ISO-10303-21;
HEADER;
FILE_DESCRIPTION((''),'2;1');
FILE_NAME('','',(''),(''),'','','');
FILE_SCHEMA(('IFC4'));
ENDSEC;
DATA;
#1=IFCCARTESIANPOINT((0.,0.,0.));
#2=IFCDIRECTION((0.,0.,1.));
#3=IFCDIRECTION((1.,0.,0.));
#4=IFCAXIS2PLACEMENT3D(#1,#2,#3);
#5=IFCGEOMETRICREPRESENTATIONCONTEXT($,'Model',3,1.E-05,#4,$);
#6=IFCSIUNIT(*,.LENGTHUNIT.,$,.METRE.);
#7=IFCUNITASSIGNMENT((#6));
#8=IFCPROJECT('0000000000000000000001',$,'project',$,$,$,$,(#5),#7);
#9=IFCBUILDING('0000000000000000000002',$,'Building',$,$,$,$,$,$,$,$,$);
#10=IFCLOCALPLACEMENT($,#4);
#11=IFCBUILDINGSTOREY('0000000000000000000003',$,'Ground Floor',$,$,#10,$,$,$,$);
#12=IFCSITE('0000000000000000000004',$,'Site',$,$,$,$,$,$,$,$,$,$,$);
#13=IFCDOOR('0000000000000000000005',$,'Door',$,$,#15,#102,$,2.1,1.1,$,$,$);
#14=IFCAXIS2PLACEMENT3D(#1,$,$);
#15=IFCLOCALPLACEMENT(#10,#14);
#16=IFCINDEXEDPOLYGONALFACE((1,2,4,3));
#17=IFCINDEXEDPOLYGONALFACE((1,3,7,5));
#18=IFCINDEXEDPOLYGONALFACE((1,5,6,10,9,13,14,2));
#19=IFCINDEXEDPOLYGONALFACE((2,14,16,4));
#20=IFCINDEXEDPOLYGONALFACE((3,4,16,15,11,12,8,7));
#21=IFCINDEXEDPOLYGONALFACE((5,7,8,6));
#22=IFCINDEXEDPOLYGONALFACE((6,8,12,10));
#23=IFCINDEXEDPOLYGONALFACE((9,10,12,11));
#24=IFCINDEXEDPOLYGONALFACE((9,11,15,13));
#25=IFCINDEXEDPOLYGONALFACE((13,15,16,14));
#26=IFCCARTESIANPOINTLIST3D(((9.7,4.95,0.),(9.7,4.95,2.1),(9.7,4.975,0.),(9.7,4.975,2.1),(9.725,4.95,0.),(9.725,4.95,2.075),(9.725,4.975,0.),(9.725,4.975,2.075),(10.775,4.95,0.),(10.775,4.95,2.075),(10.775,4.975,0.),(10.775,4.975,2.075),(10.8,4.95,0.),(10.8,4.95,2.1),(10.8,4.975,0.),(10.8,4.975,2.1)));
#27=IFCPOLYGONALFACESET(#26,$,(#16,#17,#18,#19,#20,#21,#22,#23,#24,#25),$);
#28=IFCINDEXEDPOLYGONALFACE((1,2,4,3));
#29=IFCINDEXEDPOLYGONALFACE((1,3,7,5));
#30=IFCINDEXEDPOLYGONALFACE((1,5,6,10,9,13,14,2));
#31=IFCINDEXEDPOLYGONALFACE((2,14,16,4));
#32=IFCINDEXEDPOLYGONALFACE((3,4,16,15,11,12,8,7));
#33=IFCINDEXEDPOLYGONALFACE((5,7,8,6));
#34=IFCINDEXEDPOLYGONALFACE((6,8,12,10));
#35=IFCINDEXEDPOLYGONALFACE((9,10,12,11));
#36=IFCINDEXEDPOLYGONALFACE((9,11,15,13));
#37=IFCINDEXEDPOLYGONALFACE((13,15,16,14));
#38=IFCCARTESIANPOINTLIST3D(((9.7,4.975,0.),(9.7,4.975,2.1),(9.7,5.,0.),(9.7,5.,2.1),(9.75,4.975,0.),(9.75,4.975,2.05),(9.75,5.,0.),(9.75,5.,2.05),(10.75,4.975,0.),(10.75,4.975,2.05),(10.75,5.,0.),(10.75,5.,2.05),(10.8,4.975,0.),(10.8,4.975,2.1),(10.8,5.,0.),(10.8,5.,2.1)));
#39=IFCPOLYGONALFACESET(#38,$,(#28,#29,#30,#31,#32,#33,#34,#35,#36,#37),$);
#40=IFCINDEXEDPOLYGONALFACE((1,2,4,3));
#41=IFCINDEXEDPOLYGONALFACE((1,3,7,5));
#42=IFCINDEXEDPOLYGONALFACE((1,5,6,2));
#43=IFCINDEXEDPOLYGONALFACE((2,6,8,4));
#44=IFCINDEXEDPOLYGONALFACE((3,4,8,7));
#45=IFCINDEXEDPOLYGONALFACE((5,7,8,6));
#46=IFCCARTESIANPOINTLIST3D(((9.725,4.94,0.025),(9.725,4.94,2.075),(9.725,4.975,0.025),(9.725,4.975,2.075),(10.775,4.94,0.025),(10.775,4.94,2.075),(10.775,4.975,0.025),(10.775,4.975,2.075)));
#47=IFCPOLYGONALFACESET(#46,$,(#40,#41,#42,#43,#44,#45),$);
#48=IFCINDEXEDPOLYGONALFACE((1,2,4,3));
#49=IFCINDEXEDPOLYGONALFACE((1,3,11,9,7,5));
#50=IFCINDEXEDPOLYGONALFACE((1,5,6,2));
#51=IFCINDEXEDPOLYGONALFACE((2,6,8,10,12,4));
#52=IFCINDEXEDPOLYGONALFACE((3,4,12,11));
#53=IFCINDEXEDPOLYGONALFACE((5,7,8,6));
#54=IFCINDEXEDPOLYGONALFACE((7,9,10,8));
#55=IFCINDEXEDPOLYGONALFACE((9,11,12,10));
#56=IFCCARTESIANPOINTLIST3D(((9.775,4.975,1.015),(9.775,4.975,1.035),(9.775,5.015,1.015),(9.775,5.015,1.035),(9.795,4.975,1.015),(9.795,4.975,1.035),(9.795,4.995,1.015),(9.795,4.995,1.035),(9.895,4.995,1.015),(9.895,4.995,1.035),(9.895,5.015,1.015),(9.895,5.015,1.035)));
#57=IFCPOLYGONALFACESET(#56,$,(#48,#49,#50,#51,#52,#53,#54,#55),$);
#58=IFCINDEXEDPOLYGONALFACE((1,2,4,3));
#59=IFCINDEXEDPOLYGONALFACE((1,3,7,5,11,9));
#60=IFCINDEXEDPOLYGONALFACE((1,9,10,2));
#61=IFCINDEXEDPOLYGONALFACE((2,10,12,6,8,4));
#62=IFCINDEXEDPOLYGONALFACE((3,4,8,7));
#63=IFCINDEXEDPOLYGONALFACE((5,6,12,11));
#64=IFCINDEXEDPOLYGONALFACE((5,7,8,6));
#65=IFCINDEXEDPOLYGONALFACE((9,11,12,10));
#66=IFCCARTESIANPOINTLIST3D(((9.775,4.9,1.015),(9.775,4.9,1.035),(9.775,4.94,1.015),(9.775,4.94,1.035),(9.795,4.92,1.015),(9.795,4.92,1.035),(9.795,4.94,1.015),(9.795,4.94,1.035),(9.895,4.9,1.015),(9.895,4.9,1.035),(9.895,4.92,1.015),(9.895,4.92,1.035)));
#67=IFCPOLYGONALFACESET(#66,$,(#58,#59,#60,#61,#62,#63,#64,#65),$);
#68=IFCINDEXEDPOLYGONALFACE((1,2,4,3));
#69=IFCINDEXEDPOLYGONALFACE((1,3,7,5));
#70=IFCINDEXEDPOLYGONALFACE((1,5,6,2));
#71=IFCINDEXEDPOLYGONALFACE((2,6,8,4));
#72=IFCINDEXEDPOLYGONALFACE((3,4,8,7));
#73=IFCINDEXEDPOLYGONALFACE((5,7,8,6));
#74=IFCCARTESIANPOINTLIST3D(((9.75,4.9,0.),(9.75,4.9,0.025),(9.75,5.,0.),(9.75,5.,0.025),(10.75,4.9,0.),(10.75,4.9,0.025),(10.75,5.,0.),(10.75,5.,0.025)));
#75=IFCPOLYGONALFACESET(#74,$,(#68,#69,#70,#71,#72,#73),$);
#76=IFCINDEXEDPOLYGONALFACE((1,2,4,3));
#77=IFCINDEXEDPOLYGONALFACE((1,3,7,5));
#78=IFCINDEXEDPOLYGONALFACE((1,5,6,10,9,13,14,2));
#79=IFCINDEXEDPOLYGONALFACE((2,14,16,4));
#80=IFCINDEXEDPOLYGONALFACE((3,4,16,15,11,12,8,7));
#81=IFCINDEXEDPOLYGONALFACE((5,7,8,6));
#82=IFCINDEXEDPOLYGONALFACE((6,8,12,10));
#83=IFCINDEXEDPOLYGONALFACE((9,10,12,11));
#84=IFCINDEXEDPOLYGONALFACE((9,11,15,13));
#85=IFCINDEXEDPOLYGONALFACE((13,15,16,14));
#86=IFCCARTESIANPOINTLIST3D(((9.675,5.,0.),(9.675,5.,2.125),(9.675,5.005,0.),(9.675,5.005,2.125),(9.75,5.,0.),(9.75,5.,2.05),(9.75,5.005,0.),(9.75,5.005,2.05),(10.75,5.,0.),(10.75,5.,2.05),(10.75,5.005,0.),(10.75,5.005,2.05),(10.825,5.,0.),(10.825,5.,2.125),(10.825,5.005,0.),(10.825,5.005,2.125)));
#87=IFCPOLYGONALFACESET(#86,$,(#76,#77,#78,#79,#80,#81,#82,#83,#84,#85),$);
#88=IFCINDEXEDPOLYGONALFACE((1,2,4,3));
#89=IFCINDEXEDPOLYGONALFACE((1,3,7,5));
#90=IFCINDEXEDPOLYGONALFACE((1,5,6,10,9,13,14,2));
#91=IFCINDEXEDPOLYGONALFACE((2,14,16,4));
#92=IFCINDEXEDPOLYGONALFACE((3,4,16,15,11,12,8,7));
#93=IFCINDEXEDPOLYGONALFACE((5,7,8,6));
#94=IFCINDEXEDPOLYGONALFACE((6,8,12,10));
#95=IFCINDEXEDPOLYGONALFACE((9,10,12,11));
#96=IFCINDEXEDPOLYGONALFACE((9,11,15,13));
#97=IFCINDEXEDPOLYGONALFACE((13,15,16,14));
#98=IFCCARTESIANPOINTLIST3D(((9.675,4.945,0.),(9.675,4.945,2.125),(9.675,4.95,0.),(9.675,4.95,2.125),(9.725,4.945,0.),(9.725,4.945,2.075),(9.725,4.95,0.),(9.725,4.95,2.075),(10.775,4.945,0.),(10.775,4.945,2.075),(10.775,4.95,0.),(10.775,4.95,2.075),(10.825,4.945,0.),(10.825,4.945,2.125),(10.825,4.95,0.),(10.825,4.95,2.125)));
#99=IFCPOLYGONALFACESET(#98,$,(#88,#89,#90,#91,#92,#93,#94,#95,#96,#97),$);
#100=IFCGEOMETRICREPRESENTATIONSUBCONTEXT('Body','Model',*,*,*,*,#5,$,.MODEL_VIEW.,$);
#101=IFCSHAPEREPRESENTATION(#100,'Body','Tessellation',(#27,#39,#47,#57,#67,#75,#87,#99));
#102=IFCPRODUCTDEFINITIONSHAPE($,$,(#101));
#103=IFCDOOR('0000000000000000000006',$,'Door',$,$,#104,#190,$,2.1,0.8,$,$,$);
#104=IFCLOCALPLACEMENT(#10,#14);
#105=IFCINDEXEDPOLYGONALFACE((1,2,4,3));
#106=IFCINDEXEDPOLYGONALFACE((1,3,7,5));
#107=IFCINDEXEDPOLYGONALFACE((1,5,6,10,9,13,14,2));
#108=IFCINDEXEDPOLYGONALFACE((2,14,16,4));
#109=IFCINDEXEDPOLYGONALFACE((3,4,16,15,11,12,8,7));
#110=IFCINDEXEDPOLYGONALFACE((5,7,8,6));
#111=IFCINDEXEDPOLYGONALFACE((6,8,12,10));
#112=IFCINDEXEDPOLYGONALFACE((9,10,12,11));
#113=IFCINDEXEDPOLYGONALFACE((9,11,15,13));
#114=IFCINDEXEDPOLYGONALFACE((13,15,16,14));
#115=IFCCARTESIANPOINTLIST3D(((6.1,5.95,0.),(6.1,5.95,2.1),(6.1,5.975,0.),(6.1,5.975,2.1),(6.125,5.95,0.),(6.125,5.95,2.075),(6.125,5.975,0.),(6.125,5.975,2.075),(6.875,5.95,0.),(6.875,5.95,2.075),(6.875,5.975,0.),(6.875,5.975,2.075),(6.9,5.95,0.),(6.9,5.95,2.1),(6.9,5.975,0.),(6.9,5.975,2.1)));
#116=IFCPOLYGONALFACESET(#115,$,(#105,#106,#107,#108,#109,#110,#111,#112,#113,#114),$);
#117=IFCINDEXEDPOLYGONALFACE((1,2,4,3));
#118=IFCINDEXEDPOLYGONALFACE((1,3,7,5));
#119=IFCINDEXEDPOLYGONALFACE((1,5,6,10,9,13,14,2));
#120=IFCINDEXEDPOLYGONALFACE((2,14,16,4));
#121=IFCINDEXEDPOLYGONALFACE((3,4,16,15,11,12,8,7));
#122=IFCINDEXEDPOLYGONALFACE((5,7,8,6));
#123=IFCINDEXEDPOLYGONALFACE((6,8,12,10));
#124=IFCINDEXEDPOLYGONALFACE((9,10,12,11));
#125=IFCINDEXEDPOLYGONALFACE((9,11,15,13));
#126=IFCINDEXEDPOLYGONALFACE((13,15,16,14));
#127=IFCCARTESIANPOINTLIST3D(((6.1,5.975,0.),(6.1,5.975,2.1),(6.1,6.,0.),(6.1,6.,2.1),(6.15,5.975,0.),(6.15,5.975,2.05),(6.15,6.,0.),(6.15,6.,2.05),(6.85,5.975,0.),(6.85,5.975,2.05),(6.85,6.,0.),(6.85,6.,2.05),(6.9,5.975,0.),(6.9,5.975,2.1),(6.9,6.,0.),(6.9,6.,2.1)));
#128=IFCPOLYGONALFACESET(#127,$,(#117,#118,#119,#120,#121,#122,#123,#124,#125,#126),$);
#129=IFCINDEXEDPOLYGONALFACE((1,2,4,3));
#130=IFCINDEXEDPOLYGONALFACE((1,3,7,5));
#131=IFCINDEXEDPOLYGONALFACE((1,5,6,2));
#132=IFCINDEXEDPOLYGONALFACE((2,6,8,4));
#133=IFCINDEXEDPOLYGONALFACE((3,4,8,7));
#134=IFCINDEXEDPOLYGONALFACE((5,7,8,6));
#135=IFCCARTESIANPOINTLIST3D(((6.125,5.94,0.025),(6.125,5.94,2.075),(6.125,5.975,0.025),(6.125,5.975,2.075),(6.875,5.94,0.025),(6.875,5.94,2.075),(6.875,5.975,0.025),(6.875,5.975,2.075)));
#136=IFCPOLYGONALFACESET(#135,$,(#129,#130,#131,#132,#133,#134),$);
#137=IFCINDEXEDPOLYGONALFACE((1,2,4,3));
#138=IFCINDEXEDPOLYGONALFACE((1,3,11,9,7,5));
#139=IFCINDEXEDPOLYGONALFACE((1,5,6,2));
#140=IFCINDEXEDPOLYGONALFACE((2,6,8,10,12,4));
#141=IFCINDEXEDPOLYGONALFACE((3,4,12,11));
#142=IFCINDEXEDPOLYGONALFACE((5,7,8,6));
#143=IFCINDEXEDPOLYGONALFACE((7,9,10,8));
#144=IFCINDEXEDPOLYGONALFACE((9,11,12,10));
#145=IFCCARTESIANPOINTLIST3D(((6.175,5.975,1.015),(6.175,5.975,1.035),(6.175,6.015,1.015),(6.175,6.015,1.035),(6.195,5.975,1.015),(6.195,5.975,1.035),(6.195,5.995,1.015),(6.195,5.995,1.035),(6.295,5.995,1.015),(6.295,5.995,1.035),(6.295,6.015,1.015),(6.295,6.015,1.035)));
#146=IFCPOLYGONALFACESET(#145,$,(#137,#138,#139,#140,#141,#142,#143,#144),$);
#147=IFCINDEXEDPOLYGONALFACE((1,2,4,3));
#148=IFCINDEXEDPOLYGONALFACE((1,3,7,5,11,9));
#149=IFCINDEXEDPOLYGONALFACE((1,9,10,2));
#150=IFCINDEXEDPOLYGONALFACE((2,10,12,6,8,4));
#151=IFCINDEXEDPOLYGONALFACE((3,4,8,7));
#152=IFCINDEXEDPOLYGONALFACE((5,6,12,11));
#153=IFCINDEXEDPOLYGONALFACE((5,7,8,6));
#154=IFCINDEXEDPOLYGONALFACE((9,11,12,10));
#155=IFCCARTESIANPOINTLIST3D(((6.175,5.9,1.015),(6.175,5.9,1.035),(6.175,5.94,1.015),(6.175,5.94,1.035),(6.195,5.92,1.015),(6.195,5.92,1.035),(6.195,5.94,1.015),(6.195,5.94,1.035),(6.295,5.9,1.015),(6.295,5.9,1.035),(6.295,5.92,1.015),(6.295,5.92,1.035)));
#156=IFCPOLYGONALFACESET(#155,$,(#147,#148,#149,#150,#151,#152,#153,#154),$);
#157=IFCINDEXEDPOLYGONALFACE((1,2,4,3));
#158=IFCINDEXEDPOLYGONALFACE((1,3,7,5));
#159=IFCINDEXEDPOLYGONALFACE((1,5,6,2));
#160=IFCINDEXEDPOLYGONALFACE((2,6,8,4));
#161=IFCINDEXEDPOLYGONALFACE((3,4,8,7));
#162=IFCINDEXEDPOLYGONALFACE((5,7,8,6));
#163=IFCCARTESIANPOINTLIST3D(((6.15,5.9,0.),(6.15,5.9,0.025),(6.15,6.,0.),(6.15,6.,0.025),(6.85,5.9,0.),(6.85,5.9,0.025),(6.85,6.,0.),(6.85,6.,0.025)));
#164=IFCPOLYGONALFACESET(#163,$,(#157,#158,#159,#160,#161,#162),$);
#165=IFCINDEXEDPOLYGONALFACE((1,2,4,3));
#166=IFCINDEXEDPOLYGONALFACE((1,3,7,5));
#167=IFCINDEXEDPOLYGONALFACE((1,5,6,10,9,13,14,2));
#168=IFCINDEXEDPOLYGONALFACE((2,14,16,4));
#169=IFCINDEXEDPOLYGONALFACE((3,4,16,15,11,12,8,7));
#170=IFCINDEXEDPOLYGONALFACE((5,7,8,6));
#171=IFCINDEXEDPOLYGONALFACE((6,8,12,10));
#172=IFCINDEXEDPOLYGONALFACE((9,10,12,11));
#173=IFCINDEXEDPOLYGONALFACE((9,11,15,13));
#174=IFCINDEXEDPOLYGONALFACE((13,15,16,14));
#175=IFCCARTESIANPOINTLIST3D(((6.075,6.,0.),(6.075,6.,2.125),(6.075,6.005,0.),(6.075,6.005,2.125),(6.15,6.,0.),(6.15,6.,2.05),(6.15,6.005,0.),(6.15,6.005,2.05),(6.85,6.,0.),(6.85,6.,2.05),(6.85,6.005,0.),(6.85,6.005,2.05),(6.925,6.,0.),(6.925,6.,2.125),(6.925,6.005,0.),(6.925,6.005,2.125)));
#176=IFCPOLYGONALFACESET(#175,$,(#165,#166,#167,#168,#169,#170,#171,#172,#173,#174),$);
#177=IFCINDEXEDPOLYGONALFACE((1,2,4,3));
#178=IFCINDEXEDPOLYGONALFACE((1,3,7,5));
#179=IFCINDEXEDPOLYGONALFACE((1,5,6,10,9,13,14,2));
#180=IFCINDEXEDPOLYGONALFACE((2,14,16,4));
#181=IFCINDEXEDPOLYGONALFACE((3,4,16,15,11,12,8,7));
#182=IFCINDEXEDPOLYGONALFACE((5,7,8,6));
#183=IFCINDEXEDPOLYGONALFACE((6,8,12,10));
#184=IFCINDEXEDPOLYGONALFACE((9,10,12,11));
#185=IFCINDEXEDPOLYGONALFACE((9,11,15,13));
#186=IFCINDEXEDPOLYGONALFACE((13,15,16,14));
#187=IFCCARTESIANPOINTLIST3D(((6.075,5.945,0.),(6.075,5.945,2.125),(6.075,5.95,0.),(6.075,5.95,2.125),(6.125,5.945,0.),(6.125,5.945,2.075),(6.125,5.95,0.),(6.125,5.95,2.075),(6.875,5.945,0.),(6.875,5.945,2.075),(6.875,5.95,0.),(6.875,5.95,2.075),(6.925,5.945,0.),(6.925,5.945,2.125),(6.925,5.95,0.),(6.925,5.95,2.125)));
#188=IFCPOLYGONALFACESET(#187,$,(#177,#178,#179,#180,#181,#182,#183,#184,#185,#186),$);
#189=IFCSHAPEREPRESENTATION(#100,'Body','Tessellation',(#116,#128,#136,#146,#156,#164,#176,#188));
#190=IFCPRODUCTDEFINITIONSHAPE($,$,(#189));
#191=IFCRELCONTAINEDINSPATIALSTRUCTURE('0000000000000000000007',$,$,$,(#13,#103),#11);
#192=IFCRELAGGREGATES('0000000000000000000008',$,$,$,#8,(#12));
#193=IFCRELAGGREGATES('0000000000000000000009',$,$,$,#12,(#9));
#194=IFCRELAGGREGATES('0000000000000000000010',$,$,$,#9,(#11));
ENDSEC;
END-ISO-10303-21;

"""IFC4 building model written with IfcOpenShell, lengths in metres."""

from ifc_helpers import new_model, si_unit, frame, origin_with_axes, place, context, subcontext, project, spatial, line, indexed_curve, outline, extrude, element, save


model = new_model("IFC4")

# Units and contexts
model_context = context("Model", 3, precision=1e-05, world=origin_with_axes())
body_context = subcontext(model_context, "Body", "Model", "MODEL_VIEW")
ifc_project = project(units=[si_unit("LENGTHUNIT", "METRE")], contexts=[model_context])

# Site, building, storey
site = spatial("IfcSite", under=ifc_project, Name="Site")
building = spatial("IfcBuilding", under=site, Name="Building")
storey_placement = place(None, origin_with_axes())
storey = spatial("IfcBuildingStorey", under=building, at=storey_placement, Name="Ground Floor")

# Doors
door_1_placement = place(storey_placement, frame((10.8, 5.0, 0.0), z_axis=(0.0, 0.0, 1.0), x_axis=(-1.0, 0.0, 0.0)))
element("IfcDoor", 1, at=door_1_placement, inside=storey, Name="Door", OverallHeight=2.1, OverallWidth=1.1, context=body_context, shape_type="SweptSolid", body=[
    extrude(outline(indexed_curve([(0.0, 0.0), (0.0, 2.1), (1.1, 2.1), (1.1, 0.0), (1.075, 0.0), (1.075, 2.075), (0.025, 2.075), (0.025, 0.0)], segments=[line(1, 2, 3, 4, 5, 6, 7, 8, 1)])), frame((0.0, 0.025, 0.0), z_axis=(0.0, -1.0, 0.0), x_axis=(1.0, 0.0, 0.0)), (0.0, 0.0, -1.0), 0.025),
    extrude(outline(indexed_curve([(0.0, 0.0), (0.0, 2.1), (1.1, 2.1), (1.1, 0.0), (1.05, 0.0), (1.05, 2.05), (0.05, 2.05), (0.05, 0.0)], segments=[line(1, 2, 3, 4, 5, 6, 7, 8, 1)])), frame((0.0, 0.0, 0.0), z_axis=(0.0, -1.0, 0.0), x_axis=(1.0, 0.0, 0.0)), (0.0, 0.0, -1.0), 0.025),
    extrude(outline(indexed_curve([(0.0, 0.0), (1.05, 0.0), (1.05, 0.035), (0.0, 0.035)], segments=[line(1, 2, 3, 4, 1)])), frame((0.025, 0.025, 0.025), z_axis=(0.0, 0.0, 1.0), x_axis=(1.0, 0.0, 0.0)), (0.0, 0.0, 1.0), 2.05),
    extrude(outline(indexed_curve([(0.0, 0.0), (0.0, -0.04), (-0.12, -0.04), (-0.12, -0.02), (-0.02, -0.02), (-0.02, 0.0)], segments=[line(1, 2, 3, 4, 5, 6, 1)])), frame((1.025, 0.025, 1.015), z_axis=(0.0, 0.0, 1.0), x_axis=(1.0, 0.0, 0.0)), (0.0, 0.0, 1.0), 0.02),
    extrude(outline(indexed_curve([(0.0, 0.0), (0.0, 0.04), (-0.12, 0.04), (-0.12, 0.02), (-0.02, 0.02), (-0.02, 0.0)], segments=[line(1, 2, 3, 4, 5, 6, 1)])), frame((1.025, 0.06, 1.015), z_axis=(0.0, 0.0, 1.0), x_axis=(1.0, 0.0, 0.0)), (0.0, 0.0, 1.0), 0.02),
    extrude(outline(indexed_curve([(0.0, 0.0), (1.0, 0.0), (1.0, 0.1), (0.0, 0.1)], segments=[line(1, 2, 3, 4, 1)])), frame((0.05, 0.0, 0.0), z_axis=(0.0, 0.0, 1.0), x_axis=(1.0, 0.0, 0.0)), (0.0, 0.0, 1.0), 0.025),
    extrude(outline(indexed_curve([(0.0, 0.0), (0.0, 2.125), (1.15, 2.125), (1.15, 0.0), (1.075, 0.0), (1.075, 2.05), (0.075, 2.05), (0.075, 0.0)], segments=[line(1, 2, 3, 4, 5, 6, 7, 8, 1)])), frame((-0.025, -0.005, 0.0), z_axis=(0.0, -1.0, 0.0), x_axis=(1.0, 0.0, 0.0)), (0.0, 0.0, -1.0), 0.005),
    extrude(outline(indexed_curve([(0.0, 0.0), (0.0, 2.125), (1.15, 2.125), (1.15, 0.0), (1.1, 0.0), (1.1, 2.075), (0.05, 2.075), (0.05, 0.0)], segments=[line(1, 2, 3, 4, 5, 6, 7, 8, 1)])), frame((-0.025, 0.05, 0.0), z_axis=(0.0, -1.0, 0.0), x_axis=(1.0, 0.0, 0.0)), (0.0, 0.0, -1.0), 0.005),
])
door_2_placement = place(storey_placement, frame((6.9, 6.0, 0.0), z_axis=(0.0, 0.0, 1.0), x_axis=(-1.0, 0.0, 0.0)))
element("IfcDoor", 2, at=door_2_placement, inside=storey, Name="Door", OverallHeight=2.1, OverallWidth=0.8, context=body_context, shape_type="SweptSolid", body=[
    extrude(outline(indexed_curve([(0.0, 0.0), (0.0, 2.1), (0.8, 2.1), (0.8, 0.0), (0.775, 0.0), (0.775, 2.075), (0.025, 2.075), (0.025, 0.0)], segments=[line(1, 2, 3, 4, 5, 6, 7, 8, 1)])), frame((0.0, 0.025, 0.0), z_axis=(0.0, -1.0, 0.0), x_axis=(1.0, 0.0, 0.0)), (0.0, 0.0, -1.0), 0.025),
    extrude(outline(indexed_curve([(0.0, 0.0), (0.0, 2.1), (0.8, 2.1), (0.8, 0.0), (0.75, 0.0), (0.75, 2.05), (0.05, 2.05), (0.05, 0.0)], segments=[line(1, 2, 3, 4, 5, 6, 7, 8, 1)])), frame((0.0, 0.0, 0.0), z_axis=(0.0, -1.0, 0.0), x_axis=(1.0, 0.0, 0.0)), (0.0, 0.0, -1.0), 0.025),
    extrude(outline(indexed_curve([(0.0, 0.0), (0.75, 0.0), (0.75, 0.035), (0.0, 0.035)], segments=[line(1, 2, 3, 4, 1)])), frame((0.025, 0.025, 0.025), z_axis=(0.0, 0.0, 1.0), x_axis=(1.0, 0.0, 0.0)), (0.0, 0.0, 1.0), 2.05),
    extrude(outline(indexed_curve([(0.0, 0.0), (0.0, -0.04), (-0.12, -0.04), (-0.12, -0.02), (-0.02, -0.02), (-0.02, 0.0)], segments=[line(1, 2, 3, 4, 5, 6, 1)])), frame((0.725, 0.025, 1.015), z_axis=(0.0, 0.0, 1.0), x_axis=(1.0, 0.0, 0.0)), (0.0, 0.0, 1.0), 0.02),
    extrude(outline(indexed_curve([(0.0, 0.0), (0.0, 0.04), (-0.12, 0.04), (-0.12, 0.02), (-0.02, 0.02), (-0.02, 0.0)], segments=[line(1, 2, 3, 4, 5, 6, 1)])), frame((0.725, 0.06, 1.015), z_axis=(0.0, 0.0, 1.0), x_axis=(1.0, 0.0, 0.0)), (0.0, 0.0, 1.0), 0.02),
    extrude(outline(indexed_curve([(0.0, 0.0), (0.7, 0.0), (0.7, 0.1), (0.0, 0.1)], segments=[line(1, 2, 3, 4, 1)])), frame((0.05, 0.0, 0.0), z_axis=(0.0, 0.0, 1.0), x_axis=(1.0, 0.0, 0.0)), (0.0, 0.0, 1.0), 0.025),
    extrude(outline(indexed_curve([(0.0, 0.0), (0.0, 2.125), (0.85, 2.125), (0.85, 0.0), (0.775, 0.0), (0.775, 2.05), (0.075, 2.05), (0.075, 0.0)], segments=[line(1, 2, 3, 4, 5, 6, 7, 8, 1)])), frame((-0.025, -0.005, 0.0), z_axis=(0.0, -1.0, 0.0), x_axis=(1.0, 0.0, 0.0)), (0.0, 0.0, -1.0), 0.005),
    extrude(outline(indexed_curve([(0.0, 0.0), (0.0, 2.125), (0.85, 2.125), (0.85, 0.0), (0.8, 0.0), (0.8, 2.075), (0.05, 2.075), (0.05, 0.0)], segments=[line(1, 2, 3, 4, 5, 6, 7, 8, 1)])), frame((-0.025, 0.05, 0.0), z_axis=(0.0, -1.0, 0.0), x_axis=(1.0, 0.0, 0.0)), (0.0, 0.0, -1.0), 0.005),
])

save(model, "model.ifc")
